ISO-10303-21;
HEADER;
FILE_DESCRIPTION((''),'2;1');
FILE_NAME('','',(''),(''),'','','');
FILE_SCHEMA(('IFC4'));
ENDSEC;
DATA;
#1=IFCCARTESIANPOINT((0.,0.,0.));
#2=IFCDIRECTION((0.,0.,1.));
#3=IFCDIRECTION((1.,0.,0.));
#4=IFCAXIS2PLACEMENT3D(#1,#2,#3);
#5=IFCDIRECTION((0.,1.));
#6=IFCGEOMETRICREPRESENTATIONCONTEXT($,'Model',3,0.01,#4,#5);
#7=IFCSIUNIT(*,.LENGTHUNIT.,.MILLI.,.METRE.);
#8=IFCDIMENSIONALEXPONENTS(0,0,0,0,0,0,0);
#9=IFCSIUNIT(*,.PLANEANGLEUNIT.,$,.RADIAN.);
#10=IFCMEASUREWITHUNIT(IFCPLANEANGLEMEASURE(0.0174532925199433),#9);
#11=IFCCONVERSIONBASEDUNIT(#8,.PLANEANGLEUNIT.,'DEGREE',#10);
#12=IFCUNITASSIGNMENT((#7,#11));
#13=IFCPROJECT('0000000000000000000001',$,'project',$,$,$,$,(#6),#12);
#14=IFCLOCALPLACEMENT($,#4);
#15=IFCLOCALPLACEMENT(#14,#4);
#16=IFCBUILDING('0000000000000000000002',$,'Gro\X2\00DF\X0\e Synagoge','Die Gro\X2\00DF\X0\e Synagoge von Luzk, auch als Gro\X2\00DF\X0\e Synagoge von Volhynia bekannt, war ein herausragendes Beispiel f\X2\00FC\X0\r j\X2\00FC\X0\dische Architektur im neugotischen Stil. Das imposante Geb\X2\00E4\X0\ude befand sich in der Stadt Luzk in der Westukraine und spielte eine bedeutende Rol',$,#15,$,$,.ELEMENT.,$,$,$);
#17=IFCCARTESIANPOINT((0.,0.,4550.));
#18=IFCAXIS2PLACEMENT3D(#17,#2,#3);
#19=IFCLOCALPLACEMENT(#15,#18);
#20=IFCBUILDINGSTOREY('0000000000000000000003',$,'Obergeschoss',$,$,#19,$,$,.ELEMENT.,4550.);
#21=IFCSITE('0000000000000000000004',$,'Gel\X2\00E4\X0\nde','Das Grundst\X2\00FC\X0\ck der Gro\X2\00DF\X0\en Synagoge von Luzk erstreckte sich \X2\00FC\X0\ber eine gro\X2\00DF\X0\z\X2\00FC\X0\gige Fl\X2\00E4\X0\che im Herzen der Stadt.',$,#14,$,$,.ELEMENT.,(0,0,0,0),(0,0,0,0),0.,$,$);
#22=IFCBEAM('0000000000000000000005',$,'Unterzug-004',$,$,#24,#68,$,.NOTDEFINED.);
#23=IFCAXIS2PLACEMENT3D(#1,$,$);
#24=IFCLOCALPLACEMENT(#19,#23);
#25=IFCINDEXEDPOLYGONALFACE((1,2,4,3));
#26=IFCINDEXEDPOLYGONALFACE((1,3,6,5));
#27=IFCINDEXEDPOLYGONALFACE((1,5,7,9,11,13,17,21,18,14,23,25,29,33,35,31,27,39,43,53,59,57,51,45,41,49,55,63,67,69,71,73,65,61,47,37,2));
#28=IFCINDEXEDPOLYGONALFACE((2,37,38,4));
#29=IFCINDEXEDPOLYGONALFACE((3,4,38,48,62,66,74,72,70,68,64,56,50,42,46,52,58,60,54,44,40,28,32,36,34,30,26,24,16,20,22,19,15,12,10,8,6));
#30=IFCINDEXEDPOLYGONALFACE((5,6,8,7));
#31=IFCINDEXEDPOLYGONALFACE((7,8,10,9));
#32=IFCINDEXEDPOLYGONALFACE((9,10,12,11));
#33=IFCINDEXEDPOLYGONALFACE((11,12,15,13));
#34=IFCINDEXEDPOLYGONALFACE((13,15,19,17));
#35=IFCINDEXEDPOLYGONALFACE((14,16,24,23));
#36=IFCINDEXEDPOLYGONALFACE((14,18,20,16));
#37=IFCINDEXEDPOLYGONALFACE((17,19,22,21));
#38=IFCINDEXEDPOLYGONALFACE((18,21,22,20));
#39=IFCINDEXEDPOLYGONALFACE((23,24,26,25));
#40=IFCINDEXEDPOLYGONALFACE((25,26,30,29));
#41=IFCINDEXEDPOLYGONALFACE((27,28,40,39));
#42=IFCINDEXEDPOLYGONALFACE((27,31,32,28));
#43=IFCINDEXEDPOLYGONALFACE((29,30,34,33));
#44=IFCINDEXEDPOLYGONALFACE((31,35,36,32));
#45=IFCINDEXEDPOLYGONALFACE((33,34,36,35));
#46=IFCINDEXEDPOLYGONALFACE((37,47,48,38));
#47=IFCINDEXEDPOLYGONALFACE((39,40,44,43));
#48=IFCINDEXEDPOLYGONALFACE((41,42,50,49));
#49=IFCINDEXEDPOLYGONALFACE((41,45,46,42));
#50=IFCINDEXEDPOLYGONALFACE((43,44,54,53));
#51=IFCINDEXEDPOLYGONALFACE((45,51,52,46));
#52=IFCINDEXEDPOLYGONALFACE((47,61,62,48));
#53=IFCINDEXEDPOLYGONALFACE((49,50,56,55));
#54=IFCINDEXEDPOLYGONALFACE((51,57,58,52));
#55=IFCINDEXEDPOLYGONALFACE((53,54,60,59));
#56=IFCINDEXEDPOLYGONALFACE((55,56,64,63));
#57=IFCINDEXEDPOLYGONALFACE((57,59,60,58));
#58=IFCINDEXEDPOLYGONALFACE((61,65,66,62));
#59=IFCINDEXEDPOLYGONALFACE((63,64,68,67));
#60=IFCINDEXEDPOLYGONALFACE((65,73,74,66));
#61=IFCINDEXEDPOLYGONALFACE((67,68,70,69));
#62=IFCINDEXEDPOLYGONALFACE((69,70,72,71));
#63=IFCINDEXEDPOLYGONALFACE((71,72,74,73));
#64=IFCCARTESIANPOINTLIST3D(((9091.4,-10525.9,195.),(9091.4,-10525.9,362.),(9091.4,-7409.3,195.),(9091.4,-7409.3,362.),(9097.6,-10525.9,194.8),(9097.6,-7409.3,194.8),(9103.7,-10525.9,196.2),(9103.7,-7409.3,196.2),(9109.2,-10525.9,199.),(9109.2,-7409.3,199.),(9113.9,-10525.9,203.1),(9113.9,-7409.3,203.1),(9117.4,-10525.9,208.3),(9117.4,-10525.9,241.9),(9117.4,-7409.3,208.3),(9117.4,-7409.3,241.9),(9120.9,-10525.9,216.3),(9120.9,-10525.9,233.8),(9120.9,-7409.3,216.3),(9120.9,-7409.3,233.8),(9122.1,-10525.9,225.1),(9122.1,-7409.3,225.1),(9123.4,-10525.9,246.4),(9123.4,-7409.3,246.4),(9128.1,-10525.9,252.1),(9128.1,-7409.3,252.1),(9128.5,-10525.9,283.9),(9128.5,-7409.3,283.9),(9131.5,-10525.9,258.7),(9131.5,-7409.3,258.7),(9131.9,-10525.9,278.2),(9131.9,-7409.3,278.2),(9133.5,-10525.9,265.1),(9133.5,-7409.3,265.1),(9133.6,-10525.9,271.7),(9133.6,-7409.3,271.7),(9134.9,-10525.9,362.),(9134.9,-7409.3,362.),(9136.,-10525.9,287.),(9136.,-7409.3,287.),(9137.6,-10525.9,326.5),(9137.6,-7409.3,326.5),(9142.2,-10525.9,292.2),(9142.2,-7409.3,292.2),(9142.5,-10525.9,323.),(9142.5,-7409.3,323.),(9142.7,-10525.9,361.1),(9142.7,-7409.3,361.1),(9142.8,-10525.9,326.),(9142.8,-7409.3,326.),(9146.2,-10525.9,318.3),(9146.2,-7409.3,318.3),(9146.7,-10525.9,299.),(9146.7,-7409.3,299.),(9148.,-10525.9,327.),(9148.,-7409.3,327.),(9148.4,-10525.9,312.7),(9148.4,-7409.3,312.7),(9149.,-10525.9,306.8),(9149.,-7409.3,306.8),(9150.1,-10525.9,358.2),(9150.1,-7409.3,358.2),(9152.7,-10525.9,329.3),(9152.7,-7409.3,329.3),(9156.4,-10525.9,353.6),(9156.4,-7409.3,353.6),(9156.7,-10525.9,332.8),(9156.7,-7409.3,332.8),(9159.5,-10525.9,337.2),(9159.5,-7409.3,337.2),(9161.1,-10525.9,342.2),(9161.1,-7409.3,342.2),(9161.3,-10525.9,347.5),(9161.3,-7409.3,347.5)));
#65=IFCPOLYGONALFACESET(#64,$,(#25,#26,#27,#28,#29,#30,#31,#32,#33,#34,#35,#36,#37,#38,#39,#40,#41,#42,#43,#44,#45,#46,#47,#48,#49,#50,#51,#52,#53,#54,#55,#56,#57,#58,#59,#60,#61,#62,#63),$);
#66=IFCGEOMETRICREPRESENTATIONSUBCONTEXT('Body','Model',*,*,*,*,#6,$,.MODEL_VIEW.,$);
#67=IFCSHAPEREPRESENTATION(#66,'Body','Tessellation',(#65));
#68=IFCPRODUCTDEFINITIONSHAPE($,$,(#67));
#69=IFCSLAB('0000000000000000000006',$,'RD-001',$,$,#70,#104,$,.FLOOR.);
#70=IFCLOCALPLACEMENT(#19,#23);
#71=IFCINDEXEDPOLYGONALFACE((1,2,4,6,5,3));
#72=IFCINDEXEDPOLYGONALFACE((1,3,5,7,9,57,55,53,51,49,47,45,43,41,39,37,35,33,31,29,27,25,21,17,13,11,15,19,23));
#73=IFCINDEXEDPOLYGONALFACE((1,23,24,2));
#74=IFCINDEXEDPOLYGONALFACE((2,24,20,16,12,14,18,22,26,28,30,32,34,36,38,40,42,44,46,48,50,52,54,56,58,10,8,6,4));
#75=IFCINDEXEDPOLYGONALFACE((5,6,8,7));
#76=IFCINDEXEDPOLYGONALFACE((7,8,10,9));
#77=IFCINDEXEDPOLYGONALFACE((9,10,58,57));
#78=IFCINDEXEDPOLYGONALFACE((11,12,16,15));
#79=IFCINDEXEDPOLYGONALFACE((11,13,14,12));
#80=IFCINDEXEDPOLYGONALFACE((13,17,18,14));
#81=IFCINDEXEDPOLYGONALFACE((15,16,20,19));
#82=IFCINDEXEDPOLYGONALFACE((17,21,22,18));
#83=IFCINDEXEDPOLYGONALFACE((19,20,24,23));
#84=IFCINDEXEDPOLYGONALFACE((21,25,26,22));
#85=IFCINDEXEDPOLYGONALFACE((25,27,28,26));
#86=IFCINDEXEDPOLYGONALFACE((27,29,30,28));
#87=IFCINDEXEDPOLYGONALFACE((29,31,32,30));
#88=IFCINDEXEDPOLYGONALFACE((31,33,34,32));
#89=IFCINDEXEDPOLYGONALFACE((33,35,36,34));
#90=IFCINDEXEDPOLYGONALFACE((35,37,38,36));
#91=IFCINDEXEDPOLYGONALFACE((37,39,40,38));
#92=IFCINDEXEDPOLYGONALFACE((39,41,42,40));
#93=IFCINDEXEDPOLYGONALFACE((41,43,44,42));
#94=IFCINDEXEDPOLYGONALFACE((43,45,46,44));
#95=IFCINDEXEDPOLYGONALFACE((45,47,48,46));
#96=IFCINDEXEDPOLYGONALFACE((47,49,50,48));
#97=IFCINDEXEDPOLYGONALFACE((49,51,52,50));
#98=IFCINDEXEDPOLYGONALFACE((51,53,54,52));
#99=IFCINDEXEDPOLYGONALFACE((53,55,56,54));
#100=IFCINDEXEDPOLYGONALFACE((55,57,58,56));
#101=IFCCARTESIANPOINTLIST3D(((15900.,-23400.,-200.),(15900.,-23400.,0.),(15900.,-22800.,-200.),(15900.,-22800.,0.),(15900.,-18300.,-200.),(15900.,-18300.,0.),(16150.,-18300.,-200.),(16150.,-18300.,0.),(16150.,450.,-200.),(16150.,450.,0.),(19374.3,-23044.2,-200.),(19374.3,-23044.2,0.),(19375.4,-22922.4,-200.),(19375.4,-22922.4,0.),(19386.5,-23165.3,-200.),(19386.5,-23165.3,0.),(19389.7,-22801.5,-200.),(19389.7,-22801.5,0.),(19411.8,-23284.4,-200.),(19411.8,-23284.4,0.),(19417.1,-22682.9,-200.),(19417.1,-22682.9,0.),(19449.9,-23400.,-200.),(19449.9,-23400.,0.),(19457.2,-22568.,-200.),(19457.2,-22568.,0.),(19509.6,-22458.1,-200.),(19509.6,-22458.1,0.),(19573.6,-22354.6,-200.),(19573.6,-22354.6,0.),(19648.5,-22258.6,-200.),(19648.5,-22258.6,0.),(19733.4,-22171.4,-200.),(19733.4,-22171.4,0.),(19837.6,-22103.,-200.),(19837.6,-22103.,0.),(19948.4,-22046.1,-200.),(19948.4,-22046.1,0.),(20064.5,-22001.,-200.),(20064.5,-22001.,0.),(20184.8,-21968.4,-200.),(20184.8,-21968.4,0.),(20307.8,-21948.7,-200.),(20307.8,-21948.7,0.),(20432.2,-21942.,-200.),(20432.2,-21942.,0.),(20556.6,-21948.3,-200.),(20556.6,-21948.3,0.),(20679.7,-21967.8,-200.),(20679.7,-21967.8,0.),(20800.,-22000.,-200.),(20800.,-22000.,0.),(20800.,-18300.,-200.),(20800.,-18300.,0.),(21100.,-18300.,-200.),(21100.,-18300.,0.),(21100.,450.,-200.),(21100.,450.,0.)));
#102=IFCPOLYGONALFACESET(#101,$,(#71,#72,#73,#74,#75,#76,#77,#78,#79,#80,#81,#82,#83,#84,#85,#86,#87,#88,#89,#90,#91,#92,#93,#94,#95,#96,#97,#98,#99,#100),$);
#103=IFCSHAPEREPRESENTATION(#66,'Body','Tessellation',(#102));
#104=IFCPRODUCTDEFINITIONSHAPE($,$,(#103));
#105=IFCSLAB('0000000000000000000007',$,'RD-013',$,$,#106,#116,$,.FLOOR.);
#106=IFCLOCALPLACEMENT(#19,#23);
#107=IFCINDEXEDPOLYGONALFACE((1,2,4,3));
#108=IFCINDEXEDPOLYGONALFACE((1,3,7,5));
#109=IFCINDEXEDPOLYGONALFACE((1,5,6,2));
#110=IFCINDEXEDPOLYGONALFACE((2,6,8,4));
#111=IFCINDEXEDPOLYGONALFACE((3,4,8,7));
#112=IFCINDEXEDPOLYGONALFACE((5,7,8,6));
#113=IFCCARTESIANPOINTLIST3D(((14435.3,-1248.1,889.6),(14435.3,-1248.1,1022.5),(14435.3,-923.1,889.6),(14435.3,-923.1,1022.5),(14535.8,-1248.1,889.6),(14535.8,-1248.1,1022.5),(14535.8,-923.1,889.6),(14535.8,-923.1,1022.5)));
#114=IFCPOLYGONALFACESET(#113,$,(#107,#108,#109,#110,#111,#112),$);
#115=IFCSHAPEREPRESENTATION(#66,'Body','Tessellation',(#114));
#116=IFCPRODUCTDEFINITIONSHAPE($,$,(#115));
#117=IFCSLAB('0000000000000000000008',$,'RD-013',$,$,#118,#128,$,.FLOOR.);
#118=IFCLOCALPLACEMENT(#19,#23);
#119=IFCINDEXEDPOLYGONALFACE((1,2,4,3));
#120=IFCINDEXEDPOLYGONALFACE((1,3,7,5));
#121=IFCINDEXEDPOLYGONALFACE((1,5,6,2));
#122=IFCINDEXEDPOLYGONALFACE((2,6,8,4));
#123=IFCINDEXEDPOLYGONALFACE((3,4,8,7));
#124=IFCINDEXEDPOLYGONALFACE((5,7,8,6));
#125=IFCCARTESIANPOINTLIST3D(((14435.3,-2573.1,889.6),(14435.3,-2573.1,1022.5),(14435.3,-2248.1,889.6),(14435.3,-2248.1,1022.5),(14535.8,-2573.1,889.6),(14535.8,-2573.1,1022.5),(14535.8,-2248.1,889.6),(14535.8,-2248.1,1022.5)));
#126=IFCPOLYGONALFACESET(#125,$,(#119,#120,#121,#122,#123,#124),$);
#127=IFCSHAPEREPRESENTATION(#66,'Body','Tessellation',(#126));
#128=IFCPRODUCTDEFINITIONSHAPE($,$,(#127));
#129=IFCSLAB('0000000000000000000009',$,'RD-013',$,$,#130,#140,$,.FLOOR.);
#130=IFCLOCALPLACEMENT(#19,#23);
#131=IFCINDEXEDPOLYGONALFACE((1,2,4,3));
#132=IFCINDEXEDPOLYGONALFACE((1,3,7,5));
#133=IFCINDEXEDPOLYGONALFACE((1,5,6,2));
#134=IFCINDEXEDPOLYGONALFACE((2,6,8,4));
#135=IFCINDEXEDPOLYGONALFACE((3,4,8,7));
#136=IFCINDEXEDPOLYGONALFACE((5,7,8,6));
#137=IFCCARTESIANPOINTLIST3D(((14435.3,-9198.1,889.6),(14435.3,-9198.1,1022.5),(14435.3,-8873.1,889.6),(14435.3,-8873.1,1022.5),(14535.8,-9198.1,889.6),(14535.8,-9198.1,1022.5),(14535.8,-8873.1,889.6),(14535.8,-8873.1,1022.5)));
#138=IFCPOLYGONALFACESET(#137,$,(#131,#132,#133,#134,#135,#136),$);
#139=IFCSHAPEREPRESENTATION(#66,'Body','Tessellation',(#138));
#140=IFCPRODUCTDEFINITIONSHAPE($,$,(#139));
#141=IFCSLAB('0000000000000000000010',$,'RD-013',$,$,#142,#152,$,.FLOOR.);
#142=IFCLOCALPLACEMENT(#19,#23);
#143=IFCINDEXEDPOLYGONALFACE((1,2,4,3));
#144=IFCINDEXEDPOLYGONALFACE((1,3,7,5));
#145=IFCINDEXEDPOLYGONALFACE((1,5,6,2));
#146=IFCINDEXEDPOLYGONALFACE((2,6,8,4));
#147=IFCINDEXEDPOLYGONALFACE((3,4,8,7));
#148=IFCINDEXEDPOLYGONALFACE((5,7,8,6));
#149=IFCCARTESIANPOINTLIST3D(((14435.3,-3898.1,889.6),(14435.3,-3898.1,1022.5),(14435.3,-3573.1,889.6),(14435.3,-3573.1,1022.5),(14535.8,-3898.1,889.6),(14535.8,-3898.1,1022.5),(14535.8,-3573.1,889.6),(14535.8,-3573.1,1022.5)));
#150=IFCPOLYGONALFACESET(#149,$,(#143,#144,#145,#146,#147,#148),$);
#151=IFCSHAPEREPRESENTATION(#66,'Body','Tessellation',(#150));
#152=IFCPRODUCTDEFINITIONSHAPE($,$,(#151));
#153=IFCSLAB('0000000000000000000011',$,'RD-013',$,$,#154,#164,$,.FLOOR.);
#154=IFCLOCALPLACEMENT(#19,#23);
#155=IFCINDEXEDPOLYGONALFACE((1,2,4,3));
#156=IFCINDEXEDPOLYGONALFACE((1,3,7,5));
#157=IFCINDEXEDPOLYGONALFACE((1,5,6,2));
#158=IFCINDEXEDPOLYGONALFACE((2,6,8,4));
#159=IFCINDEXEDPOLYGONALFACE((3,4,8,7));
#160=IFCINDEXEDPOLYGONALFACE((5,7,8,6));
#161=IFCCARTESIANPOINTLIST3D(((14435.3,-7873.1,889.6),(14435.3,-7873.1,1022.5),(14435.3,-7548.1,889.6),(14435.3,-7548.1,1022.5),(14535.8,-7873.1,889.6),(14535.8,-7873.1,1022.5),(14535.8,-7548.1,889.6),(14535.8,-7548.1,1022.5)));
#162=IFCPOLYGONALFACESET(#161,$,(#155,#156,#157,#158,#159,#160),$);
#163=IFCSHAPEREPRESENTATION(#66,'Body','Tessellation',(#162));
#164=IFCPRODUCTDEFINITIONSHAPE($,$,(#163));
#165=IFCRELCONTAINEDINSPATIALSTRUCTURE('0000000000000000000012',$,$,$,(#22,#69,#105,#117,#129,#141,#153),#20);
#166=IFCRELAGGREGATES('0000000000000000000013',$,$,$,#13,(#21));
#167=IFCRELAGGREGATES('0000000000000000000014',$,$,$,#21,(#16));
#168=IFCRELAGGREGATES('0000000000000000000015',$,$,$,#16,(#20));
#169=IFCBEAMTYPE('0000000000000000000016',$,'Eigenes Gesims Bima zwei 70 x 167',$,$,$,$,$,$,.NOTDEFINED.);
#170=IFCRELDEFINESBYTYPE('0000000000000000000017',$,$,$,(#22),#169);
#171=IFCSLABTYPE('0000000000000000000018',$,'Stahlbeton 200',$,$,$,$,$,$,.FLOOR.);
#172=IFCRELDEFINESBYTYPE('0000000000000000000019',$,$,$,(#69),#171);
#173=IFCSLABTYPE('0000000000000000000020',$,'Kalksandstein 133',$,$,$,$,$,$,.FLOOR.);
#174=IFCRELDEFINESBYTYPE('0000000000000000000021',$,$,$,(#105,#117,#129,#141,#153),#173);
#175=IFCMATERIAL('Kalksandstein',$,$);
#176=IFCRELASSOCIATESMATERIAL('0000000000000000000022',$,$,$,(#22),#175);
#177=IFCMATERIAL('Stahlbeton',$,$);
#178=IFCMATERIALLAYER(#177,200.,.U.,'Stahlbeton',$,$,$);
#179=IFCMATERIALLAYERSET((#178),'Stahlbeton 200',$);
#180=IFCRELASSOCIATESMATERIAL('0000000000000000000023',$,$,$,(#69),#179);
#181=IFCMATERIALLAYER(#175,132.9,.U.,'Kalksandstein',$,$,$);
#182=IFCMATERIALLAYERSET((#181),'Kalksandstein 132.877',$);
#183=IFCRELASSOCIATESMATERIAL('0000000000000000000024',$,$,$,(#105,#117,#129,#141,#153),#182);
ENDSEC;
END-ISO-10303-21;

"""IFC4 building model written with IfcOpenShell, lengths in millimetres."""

from ifc_helpers import new_model, entity, si_unit, converted_unit, direction, frame, origin_with_axes, place, context, subcontext, project, spatial, line, arc, indexed_curve, outline, extrude, material, layer, layer_set, layer_usage, material_profile, profile_set, type_object, element, save


model = new_model("IFC4")

# Units and contexts
model_context = context("Model", 3, precision=0.01, world=origin_with_axes(), true_north=direction((0.0, 1.0)))
body_context = subcontext(model_context, "Body", "Model", "MODEL_VIEW")
ifc_project = project(units=[si_unit("LENGTHUNIT", "METRE", prefix="MILLI"), converted_unit("PLANEANGLEUNIT", "DEGREE", entity("IfcPlaneAngleMeasure", 0.0174532925199433), si_unit("PLANEANGLEUNIT", "RADIAN"), dimensions=[0, 0, 0, 0, 0, 0, 0])], contexts=[model_context])

# Site, building, storey
site_placement = place(None, origin_with_axes())
site = spatial("IfcSite", under=ifc_project, at=site_placement, Name="Gelände", Description="Das Grundstück der Großen Synagoge von Luzk erstreckte sich über eine großzügige Fläche im Herzen der Stadt.", CompositionType="ELEMENT", RefLatitude=(0, 0, 0, 0), RefLongitude=(0, 0, 0, 0), RefElevation=0.0)
building_placement = place(site_placement, origin_with_axes())
building = spatial("IfcBuilding", under=site, at=building_placement, Name="Große Synagoge", Description="Die Große Synagoge von Luzk, auch als Große Synagoge von Volhynia bekannt, war ein herausragendes Beispiel für jüdische Architektur im neugotischen Stil. Das imposante Gebäude befand sich in der Stadt Luzk in der Westukraine und spielte eine bedeutende Rol", CompositionType="ELEMENT")
storey_placement = place(building_placement, frame((0.0, 0.0, 4550.0), z_axis=(0.0, 0.0, 1.0), x_axis=(1.0, 0.0, 0.0)))
storey = spatial("IfcBuildingStorey", under=building, at=storey_placement, Name="Obergeschoss", CompositionType="ELEMENT", Elevation=4550.0)

# Beam
ifc_material_1 = material(Name="Kalksandstein")
ifc_material_profile_1 = material_profile(ifc_material_1, outline(indexed_curve([(40.0, -103.3), (42.2, -90.2), (37.0, -78.1), (50.8, -69.8), (57.6, -55.2), (54.7, -43.7), (46.2, -35.5), (63.4, -31.1), (69.9, -14.5), (58.6, -3.7), (43.5, 0.0), (0.0, 0.0), (0.0, -167.0), (15.1, -164.6), (26.0, -153.7), (30.7, -136.9), (26.0, -120.0), (34.5, -112.9)], segments=[arc(1, 2, 3), arc(3, 4, 5), arc(5, 6, 7), arc(7, 8, 9), arc(9, 10, 11), line(11, 12, 13), arc(13, 14, 15), arc(15, 16, 17), arc(17, 18, 1)])), Name="Kalksandstein")
ifc_profile_set_1 = profile_set([ifc_material_profile_1], Name="Eigenes Gesims Bima zwei")
beam_type_1 = type_object("IfcBeamType", Name="Eigenes Gesims Bima zwei 70 x 167", PredefinedType="NOTDEFINED")
beam_1_placement = place(storey_placement, frame((9091.4, -10525.9, 362.0), z_axis=(0.0, 0.0, 1.0), x_axis=(1.0, 0.0, 0.0)))
element("IfcBeam", 1, at=beam_1_placement, inside=storey, type_object=beam_type_1, material=ifc_profile_set_1, Name="Unterzug-004", PredefinedType="NOTDEFINED", context=body_context, shape_type="SweptSolid", body=[
    extrude(outline(indexed_curve([(40.0, -103.3), (42.2, -90.2), (37.0, -78.1), (50.8, -69.8), (57.6, -55.2), (54.7, -43.7), (46.2, -35.5), (63.4, -31.1), (69.9, -14.5), (58.6, -3.7), (43.5, 0.0), (0.0, 0.0), (0.0, -167.0), (15.1, -164.6), (26.0, -153.7), (30.7, -136.9), (26.0, -120.0), (34.5, -112.9)], segments=[arc(1, 2, 3), arc(3, 4, 5), arc(5, 6, 7), arc(7, 8, 9), arc(9, 10, 11), line(11, 12, 13), arc(13, 14, 15), arc(15, 16, 17), arc(17, 18, 1)])), frame((0.0, 3116.6, 0.0), z_axis=(0.0, -1.0, 0.0), x_axis=(1.0, 0.0, 0.0)), (0.0, 0.0, 1.0), 3116.6),
])

# Slabs
ifc_material_2 = material(Name="Stahlbeton")
ifc_layer_1 = layer(ifc_material_2, 200.0, ventilated="UNKNOWN", Name="Stahlbeton")
ifc_layer_set_1 = layer_set([ifc_layer_1], Name="Stahlbeton 200")
ifc_layer_usage_1 = layer_usage(ifc_layer_set_1, "AXIS3", "NEGATIVE", 200.0)
slab_type_1 = type_object("IfcSlabType", Name="Stahlbeton 200", PredefinedType="FLOOR")
slab_1_placement = place(storey_placement, frame((16150.0, 450.0, 0.0), z_axis=(0.0, 0.0, 1.0), x_axis=(1.0, 0.0, 0.0)))
element("IfcSlab", 2, at=slab_1_placement, inside=storey, type_object=slab_type_1, material=ifc_layer_usage_1, Name="RD-001", PredefinedType="FLOOR", context=body_context, shape_type="SweptSolid", body=[
    extrude(outline(indexed_curve([(0.0, 0.0), (0.0, -18750.0), (-250.0, -18750.0), (-250.0, -23250.0), (-250.0, -23850.0), (3299.9, -23850.0), (3251.8, -23191.9), (3583.4, -22621.4), (4096.0, -22406.9), (4650.0, -22450.0), (4650.0, -18750.0), (4950.0, -18750.0), (4950.0, 0.0)], segments=[line(1, 2, 3, 4, 5, 6), arc(6, 7, 8), arc(8, 9, 10), line(10, 11, 12, 13, 1)])), frame((0.0, 0.0, -200.0), z_axis=(0.0, 0.0, 1.0), x_axis=(1.0, 0.0, 0.0)), (0.0, 0.0, 1.0), 200.0),
])
ifc_layer_2 = layer(ifc_material_1, 132.9, ventilated="UNKNOWN", Name="Kalksandstein")
ifc_layer_set_2 = layer_set([ifc_layer_2], Name="Kalksandstein 132.877")
ifc_layer_usage_2 = layer_usage(ifc_layer_set_2, "AXIS3", "NEGATIVE", 132.9)
slab_type_2 = type_object("IfcSlabType", Name="Kalksandstein 133", PredefinedType="FLOOR")
slab_2_placement = place(storey_placement, frame((14435.3, -923.1, 1022.5), z_axis=(0.0, 0.0, 1.0), x_axis=(1.0, 0.0, 0.0)))
element("IfcSlab", 3, at=slab_2_placement, inside=storey, type_object=slab_type_2, material=ifc_layer_usage_2, Name="RD-013", PredefinedType="FLOOR", context=body_context, shape_type="SweptSolid", body=[
    extrude(outline(indexed_curve([(0.0, 0.0), (0.0, -325.0), (100.5, -325.0), (100.5, 0.0)], segments=[line(1, 2, 3, 4, 1)])), frame((0.0, 0.0, -132.9), z_axis=(0.0, 0.0, 1.0), x_axis=(1.0, 0.0, 0.0)), (0.0, 0.0, 1.0), 132.9),
])
ifc_layer_usage_3 = layer_usage(ifc_layer_set_2, "AXIS3", "NEGATIVE", 132.9)
slab_3_placement = place(storey_placement, frame((14435.3, -2248.1, 1022.5), z_axis=(0.0, 0.0, 1.0), x_axis=(1.0, 0.0, 0.0)))
element("IfcSlab", 4, at=slab_3_placement, inside=storey, type_object=slab_type_2, material=ifc_layer_usage_3, Name="RD-013", PredefinedType="FLOOR", context=body_context, shape_type="SweptSolid", body=[
    extrude(outline(indexed_curve([(0.0, 0.0), (0.0, -325.0), (100.5, -325.0), (100.5, 0.0)], segments=[line(1, 2, 3, 4, 1)])), frame((0.0, 0.0, -132.9), z_axis=(0.0, 0.0, 1.0), x_axis=(1.0, 0.0, 0.0)), (0.0, 0.0, 1.0), 132.9),
])
ifc_layer_usage_4 = layer_usage(ifc_layer_set_2, "AXIS3", "NEGATIVE", 132.9)
slab_4_placement = place(storey_placement, frame((14435.3, -8873.1, 1022.5), z_axis=(0.0, 0.0, 1.0), x_axis=(1.0, 0.0, 0.0)))
element("IfcSlab", 5, at=slab_4_placement, inside=storey, type_object=slab_type_2, material=ifc_layer_usage_4, Name="RD-013", PredefinedType="FLOOR", context=body_context, shape_type="SweptSolid", body=[
    extrude(outline(indexed_curve([(0.0, 0.0), (0.0, -325.0), (100.5, -325.0), (100.5, 0.0)], segments=[line(1, 2, 3, 4, 1)])), frame((0.0, 0.0, -132.9), z_axis=(0.0, 0.0, 1.0), x_axis=(1.0, 0.0, 0.0)), (0.0, 0.0, 1.0), 132.9),
])
ifc_layer_usage_5 = layer_usage(ifc_layer_set_2, "AXIS3", "NEGATIVE", 132.9)
slab_5_placement = place(storey_placement, frame((14435.3, -3573.1, 1022.5), z_axis=(0.0, 0.0, 1.0), x_axis=(1.0, 0.0, 0.0)))
element("IfcSlab", 6, at=slab_5_placement, inside=storey, type_object=slab_type_2, material=ifc_layer_usage_5, Name="RD-013", PredefinedType="FLOOR", context=body_context, shape_type="SweptSolid", body=[
    extrude(outline(indexed_curve([(0.0, 0.0), (0.0, -325.0), (100.5, -325.0), (100.5, 0.0)], segments=[line(1, 2, 3, 4, 1)])), frame((0.0, 0.0, -132.9), z_axis=(0.0, 0.0, 1.0), x_axis=(1.0, 0.0, 0.0)), (0.0, 0.0, 1.0), 132.9),
])
ifc_layer_usage_6 = layer_usage(ifc_layer_set_2, "AXIS3", "NEGATIVE", 132.9)
slab_6_placement = place(storey_placement, frame((14435.3, -7548.1, 1022.5), z_axis=(0.0, 0.0, 1.0), x_axis=(1.0, 0.0, 0.0)))
element("IfcSlab", 7, at=slab_6_placement, inside=storey, type_object=slab_type_2, material=ifc_layer_usage_6, Name="RD-013", PredefinedType="FLOOR", context=body_context, shape_type="SweptSolid", body=[
    extrude(outline(indexed_curve([(0.0, 0.0), (0.0, -325.0), (100.5, -325.0), (100.5, 0.0)], segments=[line(1, 2, 3, 4, 1)])), frame((0.0, 0.0, -132.9), z_axis=(0.0, 0.0, 1.0), x_axis=(1.0, 0.0, 0.0)), (0.0, 0.0, 1.0), 132.9),
])

save(model, "model.ifc")
